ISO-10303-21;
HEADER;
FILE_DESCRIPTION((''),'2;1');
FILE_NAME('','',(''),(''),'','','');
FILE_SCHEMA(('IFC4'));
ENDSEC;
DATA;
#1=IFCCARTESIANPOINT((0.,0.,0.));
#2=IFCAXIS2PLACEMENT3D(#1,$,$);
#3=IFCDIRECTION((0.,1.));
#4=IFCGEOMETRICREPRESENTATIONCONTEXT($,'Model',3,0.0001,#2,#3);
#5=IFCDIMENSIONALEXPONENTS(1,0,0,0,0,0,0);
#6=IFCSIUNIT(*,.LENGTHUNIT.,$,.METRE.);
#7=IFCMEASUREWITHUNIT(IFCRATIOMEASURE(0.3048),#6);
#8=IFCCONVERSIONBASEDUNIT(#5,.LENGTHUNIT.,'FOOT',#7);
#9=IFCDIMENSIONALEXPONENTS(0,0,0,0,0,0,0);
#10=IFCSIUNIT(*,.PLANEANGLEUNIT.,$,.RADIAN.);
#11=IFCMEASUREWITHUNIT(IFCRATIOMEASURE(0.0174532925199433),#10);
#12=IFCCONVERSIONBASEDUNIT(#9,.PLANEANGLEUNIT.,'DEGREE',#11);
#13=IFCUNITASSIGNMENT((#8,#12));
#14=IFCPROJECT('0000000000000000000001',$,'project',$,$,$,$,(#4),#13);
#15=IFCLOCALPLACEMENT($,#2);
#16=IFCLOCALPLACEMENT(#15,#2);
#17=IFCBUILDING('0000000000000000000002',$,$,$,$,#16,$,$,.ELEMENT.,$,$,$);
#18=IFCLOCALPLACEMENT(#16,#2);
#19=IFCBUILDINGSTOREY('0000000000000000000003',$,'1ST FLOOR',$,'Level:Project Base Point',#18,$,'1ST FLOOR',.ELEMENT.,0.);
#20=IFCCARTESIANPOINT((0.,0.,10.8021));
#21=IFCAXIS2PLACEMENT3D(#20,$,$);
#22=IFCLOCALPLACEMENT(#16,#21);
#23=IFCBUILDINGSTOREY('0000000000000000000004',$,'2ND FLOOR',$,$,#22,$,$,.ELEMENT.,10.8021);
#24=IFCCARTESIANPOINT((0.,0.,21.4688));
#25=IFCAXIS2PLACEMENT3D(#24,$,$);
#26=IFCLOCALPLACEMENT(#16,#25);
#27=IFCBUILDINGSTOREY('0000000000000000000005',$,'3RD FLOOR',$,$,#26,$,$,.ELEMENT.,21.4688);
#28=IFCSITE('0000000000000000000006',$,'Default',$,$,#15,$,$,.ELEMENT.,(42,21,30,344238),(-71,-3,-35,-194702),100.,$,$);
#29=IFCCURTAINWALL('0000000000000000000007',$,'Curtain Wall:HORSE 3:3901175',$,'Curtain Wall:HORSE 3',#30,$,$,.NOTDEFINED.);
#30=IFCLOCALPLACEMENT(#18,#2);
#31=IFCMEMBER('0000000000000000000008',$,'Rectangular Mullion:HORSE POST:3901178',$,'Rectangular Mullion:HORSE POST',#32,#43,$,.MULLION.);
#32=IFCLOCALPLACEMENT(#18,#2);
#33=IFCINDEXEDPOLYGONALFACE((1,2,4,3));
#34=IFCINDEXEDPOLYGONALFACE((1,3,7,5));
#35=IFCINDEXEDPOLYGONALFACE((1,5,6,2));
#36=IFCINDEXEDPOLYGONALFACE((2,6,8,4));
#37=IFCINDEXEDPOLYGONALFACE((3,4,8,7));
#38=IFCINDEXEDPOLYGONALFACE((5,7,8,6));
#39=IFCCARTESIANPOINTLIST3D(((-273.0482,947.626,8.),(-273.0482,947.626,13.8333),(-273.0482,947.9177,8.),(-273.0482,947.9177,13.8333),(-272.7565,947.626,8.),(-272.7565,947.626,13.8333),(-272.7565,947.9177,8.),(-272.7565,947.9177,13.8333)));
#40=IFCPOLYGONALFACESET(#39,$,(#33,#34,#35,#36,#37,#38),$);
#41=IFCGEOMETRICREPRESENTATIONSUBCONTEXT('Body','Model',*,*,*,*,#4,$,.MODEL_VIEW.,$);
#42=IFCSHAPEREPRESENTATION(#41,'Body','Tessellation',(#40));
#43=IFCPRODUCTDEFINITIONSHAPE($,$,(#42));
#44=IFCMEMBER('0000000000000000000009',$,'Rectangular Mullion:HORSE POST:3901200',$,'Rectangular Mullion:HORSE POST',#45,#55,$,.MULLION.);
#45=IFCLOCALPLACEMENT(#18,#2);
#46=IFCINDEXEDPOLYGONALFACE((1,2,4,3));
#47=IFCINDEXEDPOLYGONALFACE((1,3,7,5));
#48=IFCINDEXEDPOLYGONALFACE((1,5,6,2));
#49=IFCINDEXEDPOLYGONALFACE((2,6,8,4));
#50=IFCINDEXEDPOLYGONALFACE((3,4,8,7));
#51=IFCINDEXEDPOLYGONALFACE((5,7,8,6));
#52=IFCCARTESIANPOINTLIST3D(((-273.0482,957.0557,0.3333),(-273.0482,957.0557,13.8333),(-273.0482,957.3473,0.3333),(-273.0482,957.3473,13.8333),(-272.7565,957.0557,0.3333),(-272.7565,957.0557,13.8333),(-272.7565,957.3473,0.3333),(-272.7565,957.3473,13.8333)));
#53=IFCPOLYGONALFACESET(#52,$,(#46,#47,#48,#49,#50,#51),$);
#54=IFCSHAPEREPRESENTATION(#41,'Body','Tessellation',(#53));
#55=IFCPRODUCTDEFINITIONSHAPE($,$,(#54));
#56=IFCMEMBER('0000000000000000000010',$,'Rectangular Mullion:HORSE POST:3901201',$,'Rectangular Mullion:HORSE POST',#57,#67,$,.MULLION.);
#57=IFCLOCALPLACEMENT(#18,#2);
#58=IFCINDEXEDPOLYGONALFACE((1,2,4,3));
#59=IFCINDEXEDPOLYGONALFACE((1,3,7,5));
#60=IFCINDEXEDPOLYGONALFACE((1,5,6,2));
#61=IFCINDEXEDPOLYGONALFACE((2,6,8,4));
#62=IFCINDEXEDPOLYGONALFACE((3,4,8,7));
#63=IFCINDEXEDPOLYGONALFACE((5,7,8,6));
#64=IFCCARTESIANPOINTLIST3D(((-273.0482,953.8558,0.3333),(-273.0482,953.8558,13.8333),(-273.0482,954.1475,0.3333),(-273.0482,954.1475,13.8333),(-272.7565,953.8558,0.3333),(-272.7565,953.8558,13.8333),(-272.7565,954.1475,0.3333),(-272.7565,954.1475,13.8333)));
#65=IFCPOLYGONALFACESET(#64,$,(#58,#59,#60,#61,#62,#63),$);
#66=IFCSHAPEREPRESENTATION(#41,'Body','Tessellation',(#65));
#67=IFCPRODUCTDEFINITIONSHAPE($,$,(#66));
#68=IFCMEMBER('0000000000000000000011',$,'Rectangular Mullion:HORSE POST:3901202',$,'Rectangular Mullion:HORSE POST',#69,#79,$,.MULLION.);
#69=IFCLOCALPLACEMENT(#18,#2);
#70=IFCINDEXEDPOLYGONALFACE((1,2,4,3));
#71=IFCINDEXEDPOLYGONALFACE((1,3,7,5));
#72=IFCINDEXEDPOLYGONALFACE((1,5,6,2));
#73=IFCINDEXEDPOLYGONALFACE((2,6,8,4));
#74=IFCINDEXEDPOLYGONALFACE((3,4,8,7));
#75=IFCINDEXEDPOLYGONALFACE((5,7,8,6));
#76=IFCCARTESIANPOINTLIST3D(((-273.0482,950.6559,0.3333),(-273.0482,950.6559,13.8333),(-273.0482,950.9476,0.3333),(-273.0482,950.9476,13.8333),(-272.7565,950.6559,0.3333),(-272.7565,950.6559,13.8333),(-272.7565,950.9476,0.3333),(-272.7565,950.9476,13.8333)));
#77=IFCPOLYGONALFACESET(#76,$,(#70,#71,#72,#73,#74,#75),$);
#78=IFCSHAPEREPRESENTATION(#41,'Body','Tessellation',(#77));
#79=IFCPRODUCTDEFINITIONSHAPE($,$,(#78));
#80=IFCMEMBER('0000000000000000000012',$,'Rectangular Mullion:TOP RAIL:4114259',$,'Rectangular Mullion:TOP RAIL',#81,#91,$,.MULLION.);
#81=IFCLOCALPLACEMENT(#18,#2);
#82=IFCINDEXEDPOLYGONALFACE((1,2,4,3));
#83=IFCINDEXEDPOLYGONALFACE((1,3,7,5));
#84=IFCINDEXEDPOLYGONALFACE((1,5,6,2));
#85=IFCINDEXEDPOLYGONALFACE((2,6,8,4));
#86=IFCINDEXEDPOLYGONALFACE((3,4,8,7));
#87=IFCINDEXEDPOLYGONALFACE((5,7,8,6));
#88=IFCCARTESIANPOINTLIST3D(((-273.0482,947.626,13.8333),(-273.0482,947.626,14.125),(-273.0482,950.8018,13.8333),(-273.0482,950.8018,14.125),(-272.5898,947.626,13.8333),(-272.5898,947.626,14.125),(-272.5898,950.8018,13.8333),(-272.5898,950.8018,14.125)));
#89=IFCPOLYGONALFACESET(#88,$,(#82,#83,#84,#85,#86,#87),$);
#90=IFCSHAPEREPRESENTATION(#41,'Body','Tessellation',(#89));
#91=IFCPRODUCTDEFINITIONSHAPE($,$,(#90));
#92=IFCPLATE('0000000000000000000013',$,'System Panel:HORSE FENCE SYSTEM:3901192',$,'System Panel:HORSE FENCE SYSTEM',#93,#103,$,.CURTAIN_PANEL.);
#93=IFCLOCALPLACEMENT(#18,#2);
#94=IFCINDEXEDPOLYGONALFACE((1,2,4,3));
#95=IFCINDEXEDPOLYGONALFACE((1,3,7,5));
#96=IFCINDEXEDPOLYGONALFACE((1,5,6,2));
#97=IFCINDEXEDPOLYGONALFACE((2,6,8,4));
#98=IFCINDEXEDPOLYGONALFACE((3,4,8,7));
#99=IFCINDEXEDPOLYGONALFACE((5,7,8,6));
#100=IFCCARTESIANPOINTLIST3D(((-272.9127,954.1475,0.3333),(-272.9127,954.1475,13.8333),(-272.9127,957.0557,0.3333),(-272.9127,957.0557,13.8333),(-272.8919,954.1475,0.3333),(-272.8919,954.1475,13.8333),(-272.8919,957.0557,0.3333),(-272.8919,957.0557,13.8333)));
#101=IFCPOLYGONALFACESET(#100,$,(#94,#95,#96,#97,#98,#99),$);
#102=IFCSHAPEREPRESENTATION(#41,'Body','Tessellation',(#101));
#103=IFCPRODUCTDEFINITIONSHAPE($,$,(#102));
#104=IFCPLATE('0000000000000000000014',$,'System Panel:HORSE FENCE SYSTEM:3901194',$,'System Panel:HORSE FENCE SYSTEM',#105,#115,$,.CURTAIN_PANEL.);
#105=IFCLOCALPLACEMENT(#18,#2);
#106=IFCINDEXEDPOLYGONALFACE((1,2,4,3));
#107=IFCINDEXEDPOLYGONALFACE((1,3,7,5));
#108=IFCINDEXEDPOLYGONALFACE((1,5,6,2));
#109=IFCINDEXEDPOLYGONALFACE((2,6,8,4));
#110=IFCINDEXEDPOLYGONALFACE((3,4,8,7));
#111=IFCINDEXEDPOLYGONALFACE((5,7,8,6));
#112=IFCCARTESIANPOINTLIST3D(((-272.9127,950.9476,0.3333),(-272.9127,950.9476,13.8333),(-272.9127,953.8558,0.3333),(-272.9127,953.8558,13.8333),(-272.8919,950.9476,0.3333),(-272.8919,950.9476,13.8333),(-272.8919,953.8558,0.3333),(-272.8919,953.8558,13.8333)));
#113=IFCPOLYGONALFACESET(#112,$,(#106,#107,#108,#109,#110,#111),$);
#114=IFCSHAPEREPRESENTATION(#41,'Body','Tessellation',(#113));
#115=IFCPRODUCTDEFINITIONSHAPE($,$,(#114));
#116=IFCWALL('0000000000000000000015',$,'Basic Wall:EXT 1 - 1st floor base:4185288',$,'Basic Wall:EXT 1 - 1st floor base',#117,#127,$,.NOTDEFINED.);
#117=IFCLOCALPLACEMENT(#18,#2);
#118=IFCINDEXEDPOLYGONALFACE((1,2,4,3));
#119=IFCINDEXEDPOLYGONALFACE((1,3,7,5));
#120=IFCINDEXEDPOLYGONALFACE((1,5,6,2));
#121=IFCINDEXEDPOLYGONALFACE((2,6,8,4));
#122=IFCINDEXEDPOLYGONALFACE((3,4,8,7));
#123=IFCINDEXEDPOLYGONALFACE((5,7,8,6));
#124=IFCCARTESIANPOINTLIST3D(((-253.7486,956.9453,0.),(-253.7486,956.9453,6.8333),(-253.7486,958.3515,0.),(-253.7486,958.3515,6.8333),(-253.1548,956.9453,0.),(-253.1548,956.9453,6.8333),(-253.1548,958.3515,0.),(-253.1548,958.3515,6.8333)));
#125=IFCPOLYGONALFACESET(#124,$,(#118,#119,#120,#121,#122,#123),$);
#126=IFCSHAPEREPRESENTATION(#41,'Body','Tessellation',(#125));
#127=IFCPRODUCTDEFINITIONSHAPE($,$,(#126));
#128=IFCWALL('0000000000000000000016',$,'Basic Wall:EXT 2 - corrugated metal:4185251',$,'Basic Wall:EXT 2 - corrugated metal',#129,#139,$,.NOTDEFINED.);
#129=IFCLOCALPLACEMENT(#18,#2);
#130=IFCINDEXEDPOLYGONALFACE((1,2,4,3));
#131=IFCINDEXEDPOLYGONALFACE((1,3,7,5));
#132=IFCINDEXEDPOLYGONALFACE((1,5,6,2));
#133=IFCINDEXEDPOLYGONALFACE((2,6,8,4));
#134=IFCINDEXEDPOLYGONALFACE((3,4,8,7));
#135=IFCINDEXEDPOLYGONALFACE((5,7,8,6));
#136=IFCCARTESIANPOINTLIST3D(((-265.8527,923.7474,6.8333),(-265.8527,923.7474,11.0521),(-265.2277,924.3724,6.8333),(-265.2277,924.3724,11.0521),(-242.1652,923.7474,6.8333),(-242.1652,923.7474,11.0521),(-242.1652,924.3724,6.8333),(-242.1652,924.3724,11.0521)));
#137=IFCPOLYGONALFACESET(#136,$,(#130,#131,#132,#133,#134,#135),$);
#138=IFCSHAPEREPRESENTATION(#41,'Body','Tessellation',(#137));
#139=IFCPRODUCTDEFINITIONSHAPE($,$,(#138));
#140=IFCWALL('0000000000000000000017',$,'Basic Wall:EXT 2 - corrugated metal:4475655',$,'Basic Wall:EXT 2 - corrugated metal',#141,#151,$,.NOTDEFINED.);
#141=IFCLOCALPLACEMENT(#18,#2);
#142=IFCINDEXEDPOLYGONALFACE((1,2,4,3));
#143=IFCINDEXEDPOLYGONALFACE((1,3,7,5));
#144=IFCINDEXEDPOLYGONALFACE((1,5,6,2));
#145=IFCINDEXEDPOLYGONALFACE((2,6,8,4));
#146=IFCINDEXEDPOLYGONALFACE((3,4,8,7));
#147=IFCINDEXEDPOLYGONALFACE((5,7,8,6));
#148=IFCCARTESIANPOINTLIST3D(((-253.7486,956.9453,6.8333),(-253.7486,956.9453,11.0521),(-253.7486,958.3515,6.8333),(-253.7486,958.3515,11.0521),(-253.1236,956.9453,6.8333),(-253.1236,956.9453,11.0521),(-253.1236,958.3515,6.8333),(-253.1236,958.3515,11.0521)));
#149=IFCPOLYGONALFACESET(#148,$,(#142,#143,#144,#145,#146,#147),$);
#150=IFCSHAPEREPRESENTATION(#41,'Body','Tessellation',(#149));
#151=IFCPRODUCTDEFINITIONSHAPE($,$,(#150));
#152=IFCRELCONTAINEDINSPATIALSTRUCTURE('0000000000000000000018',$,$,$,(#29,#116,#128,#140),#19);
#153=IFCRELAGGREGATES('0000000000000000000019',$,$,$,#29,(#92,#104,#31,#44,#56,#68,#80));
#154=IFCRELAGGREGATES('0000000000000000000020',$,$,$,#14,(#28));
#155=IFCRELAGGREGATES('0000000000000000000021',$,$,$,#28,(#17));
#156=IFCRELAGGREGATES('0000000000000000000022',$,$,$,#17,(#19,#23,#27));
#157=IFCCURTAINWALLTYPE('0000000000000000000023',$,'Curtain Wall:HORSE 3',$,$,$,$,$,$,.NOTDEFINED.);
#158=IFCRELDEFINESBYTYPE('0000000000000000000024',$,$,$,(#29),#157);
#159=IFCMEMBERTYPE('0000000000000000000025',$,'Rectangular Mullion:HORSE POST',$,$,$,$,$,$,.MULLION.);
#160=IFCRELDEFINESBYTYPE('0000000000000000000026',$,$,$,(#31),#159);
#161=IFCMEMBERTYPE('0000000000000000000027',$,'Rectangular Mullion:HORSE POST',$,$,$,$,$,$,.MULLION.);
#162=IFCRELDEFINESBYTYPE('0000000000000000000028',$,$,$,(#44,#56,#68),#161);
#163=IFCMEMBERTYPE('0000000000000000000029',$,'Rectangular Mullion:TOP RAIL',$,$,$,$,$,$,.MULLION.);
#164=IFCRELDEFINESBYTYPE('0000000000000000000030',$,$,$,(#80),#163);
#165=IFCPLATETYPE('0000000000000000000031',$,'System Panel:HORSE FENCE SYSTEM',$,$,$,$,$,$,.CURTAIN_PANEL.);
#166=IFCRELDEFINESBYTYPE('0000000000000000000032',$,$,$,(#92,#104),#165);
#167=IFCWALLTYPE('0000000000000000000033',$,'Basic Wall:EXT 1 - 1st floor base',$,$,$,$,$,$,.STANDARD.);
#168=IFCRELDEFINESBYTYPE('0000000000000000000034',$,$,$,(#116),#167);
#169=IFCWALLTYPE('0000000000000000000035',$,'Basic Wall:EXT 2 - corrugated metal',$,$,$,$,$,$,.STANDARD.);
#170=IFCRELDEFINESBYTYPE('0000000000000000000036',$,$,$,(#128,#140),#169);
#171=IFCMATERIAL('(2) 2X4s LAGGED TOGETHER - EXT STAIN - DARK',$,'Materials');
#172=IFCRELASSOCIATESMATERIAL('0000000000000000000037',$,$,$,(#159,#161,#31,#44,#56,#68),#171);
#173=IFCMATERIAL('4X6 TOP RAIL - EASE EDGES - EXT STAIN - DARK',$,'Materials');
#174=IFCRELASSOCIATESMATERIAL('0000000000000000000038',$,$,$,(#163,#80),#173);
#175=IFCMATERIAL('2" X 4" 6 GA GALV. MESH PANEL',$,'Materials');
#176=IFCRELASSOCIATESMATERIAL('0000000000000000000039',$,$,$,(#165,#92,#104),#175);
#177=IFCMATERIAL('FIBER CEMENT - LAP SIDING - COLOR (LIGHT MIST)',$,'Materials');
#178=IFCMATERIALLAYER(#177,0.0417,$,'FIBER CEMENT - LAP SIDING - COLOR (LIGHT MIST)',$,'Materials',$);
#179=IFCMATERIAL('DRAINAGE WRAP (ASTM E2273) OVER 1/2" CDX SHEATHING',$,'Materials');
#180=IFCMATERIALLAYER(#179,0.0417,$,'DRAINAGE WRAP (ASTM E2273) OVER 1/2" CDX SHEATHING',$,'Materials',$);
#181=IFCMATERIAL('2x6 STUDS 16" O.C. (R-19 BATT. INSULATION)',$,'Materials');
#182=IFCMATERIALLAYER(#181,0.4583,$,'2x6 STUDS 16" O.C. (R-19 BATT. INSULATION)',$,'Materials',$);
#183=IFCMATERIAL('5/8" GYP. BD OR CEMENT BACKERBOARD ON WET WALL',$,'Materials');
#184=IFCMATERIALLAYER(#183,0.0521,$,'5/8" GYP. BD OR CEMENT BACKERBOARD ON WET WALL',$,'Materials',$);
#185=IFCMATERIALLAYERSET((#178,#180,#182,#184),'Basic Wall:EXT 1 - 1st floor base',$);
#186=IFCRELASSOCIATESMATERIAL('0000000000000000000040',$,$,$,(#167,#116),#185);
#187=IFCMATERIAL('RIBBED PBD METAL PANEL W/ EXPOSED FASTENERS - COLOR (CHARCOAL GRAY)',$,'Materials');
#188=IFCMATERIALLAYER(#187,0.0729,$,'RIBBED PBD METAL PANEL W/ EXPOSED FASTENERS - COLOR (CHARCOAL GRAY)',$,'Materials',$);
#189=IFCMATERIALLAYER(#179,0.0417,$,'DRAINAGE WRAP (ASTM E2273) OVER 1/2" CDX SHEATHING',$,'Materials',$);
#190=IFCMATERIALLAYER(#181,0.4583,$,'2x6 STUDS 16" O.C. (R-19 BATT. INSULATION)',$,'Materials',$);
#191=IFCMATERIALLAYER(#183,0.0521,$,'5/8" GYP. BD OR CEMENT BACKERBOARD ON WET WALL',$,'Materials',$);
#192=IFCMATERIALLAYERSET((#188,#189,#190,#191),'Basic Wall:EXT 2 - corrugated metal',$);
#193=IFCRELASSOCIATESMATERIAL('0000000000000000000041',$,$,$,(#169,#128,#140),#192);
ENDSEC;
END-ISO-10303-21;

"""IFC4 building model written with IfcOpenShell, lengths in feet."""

from ifc_helpers import new_model, entity, si_unit, converted_unit, direction, frame, frame_2d, origin, origin_2d_with_axis, place, context, subcontext, project, spatial, polyline, rectangle, outline, extrude, source, transform, mapped, material, layer, layer_set, layer_usage, material_profile, profile_set, profile_usage, type_object, type_shapes, element, aggregate, save


model = new_model("IFC4")

# Units and contexts
model_context = context("Model", 3, precision=0.0001, world=origin(), true_north=direction((0.0, 1.0)))
body_context = subcontext(model_context, "Body", "Model", "MODEL_VIEW")
ifc_project = project(units=[converted_unit("LENGTHUNIT", "FOOT", entity("IfcRatioMeasure", 0.3048), si_unit("LENGTHUNIT", "METRE"), dimensions=[1, 0, 0, 0, 0, 0, 0]), converted_unit("PLANEANGLEUNIT", "DEGREE", entity("IfcRatioMeasure", 0.0174532925199433), si_unit("PLANEANGLEUNIT", "RADIAN"), dimensions=[0, 0, 0, 0, 0, 0, 0])], contexts=[model_context])

# Site, building, storey
site_placement = place(None, origin())
site = spatial("IfcSite", under=ifc_project, at=site_placement, Name="Default", CompositionType="ELEMENT", RefLatitude=(42, 21, 30, 344238), RefLongitude=(-71, -3, -35, -194702), RefElevation=100.0)
building_placement = place(site_placement, origin())
building = spatial("IfcBuilding", under=site, at=building_placement, CompositionType="ELEMENT")
storey_1_placement = place(building_placement, origin())
storey_1 = spatial("IfcBuildingStorey", under=building, at=storey_1_placement, Name="1ST FLOOR", ObjectType="Level:Project Base Point", LongName="1ST FLOOR", CompositionType="ELEMENT", Elevation=0.0)

# Curtain wall, members, plates
curtain_wall_type = type_object("IfcCurtainWallType", Name="Curtain Wall:HORSE 3", PredefinedType="NOTDEFINED")
curtain_wall_placement = place(storey_1_placement, origin())
curtain_wall = element("IfcCurtainWall", 1, at=curtain_wall_placement, inside=storey_1, type_object=curtain_wall_type, Name="Curtain Wall:HORSE 3:3901175", ObjectType="Curtain Wall:HORSE 3", PredefinedType="NOTDEFINED")
ifc_material_1 = material(Name="(2) 2X4s LAGGED TOGETHER - EXT STAIN - DARK", Category="Materials")
ifc_material_profile_1 = material_profile(ifc_material_1, rectangle(XDim=0.2917, YDim=0.2917, at=frame_2d((0.0, 0.0), x_axis=(1.0, 0.0))), Name="HORSE POST")
ifc_profile_set_1 = profile_set([ifc_material_profile_1], Name="HORSE POST")
ifc_profile_usage_1 = profile_usage(ifc_profile_set_1)
member_type_1 = type_object("IfcMemberType", Name="Rectangular Mullion:HORSE POST", PredefinedType="MULLION", material=ifc_profile_set_1)
shared_shape_1 = source(origin(), body_context, "Body", "SweptSolid", [
    extrude(rectangle(XDim=0.2917, YDim=0.2917, at=origin_2d_with_axis()), frame((-0.1458, 0.1458, -5.8333), z_axis=(0.0, 0.0, 1.0), x_axis=(0.0, -1.0, 0.0)), (0.0, 0.0, 1.0), 5.8333),
])
type_shapes(member_type_1, [shared_shape_1])
storey_2_placement = place(building_placement, frame((0.0, 0.0, 21.4688)))
member_1_placement = place(storey_2_placement, frame((-272.7565, 947.626, -13.4688), z_axis=(0.0, 0.0, -1.0), x_axis=(0.0, -1.0, 0.0)))
member_1 = element("IfcMember", 2, at=member_1_placement, type_object=member_type_1, material=ifc_profile_usage_1, Name="Rectangular Mullion:HORSE POST:3901178", ObjectType="Rectangular Mullion:HORSE POST", PredefinedType="MULLION", context=body_context, shape_type="MappedRepresentation", body=[
    mapped(shared_shape_1, transform((0.0, 0.0, 0.0), scale=1.0)),
])
ifc_material_2 = material(Name="4X6 TOP RAIL - EASE EDGES - EXT STAIN - DARK", Category="Materials")
ifc_material_profile_2 = material_profile(ifc_material_2, rectangle(XDim=0.4583, YDim=0.2917, at=origin_2d_with_axis()), Name="TOP RAIL")
ifc_profile_set_2 = profile_set([ifc_material_profile_2], Name="TOP RAIL")
storey_3_placement = place(building_placement, frame((0.0, 0.0, 10.8021)))
ifc_profile_usage_2 = profile_usage(ifc_profile_set_1)
member_type_2 = type_object("IfcMemberType", Name="Rectangular Mullion:HORSE POST", PredefinedType="MULLION", material=ifc_profile_set_1)
shared_shape_2 = source(origin(), body_context, "Body", "SweptSolid", [
    extrude(rectangle(XDim=0.2917, YDim=0.2917, at=origin_2d_with_axis()), frame((0.0, 0.1458, -13.5), z_axis=(0.0, 0.0, 1.0), x_axis=(0.0, -1.0, 0.0)), (0.0, 0.0, 1.0), 13.5),
])
type_shapes(member_type_2, [shared_shape_2])
member_2_placement = place(storey_3_placement, frame((-272.7565, 957.2015, -10.4688), z_axis=(0.0, 0.0, -1.0), x_axis=(0.0, -1.0, 0.0)))
member_2 = element("IfcMember", 3, at=member_2_placement, type_object=member_type_2, material=ifc_profile_usage_2, Name="Rectangular Mullion:HORSE POST:3901200", ObjectType="Rectangular Mullion:HORSE POST", PredefinedType="MULLION", context=body_context, shape_type="MappedRepresentation", body=[
    mapped(shared_shape_2, transform((0.0, 0.0, 0.0), scale=1.0)),
])
ifc_profile_usage_3 = profile_usage(ifc_profile_set_1)
member_3_placement = place(storey_3_placement, frame((-272.7565, 954.0016, -10.4688), z_axis=(0.0, 0.0, -1.0), x_axis=(0.0, -1.0, 0.0)))
member_3 = element("IfcMember", 4, at=member_3_placement, type_object=member_type_2, material=ifc_profile_usage_3, Name="Rectangular Mullion:HORSE POST:3901201", ObjectType="Rectangular Mullion:HORSE POST", PredefinedType="MULLION", context=body_context, shape_type="MappedRepresentation", body=[
    mapped(shared_shape_2, transform((0.0, 0.0, 0.0), scale=1.0)),
])
ifc_profile_usage_4 = profile_usage(ifc_profile_set_1)
member_4_placement = place(storey_3_placement, frame((-272.7565, 950.8018, -10.4688), z_axis=(0.0, 0.0, -1.0), x_axis=(0.0, -1.0, 0.0)))
member_4 = element("IfcMember", 5, at=member_4_placement, type_object=member_type_2, material=ifc_profile_usage_4, Name="Rectangular Mullion:HORSE POST:3901202", ObjectType="Rectangular Mullion:HORSE POST", PredefinedType="MULLION", context=body_context, shape_type="MappedRepresentation", body=[
    mapped(shared_shape_2, transform((0.0, 0.0, 0.0), scale=1.0)),
])
ifc_profile_usage_5 = profile_usage(ifc_profile_set_2)
member_type_3 = type_object("IfcMemberType", Name="Rectangular Mullion:TOP RAIL", PredefinedType="MULLION", material=ifc_profile_set_2)
shared_shape_3 = source(origin(), body_context, "Body", "SweptSolid", [
    extrude(rectangle(XDim=0.4583, YDim=0.2917, at=origin_2d_with_axis()), frame((-0.1458, 0.0625, -3.1758), z_axis=(0.0, 0.0, 1.0), x_axis=(0.0, -1.0, 0.0)), (0.0, 0.0, 1.0), 3.1758),
])
type_shapes(member_type_3, [shared_shape_3])
member_5_placement = place(storey_1_placement, frame((-272.7565, 947.626, 14.125), z_axis=(0.0, -1.0, 0.0), x_axis=(0.0, 0.0, 1.0)))
member_5 = element("IfcMember", 6, at=member_5_placement, type_object=member_type_3, material=ifc_profile_usage_5, Name="Rectangular Mullion:TOP RAIL:4114259", ObjectType="Rectangular Mullion:TOP RAIL", PredefinedType="MULLION", context=body_context, shape_type="MappedRepresentation", body=[
    mapped(shared_shape_3, transform((0.0, 0.0, 0.0), scale=1.0)),
])
ifc_material_3 = material(Name="2\" X 4\" 6 GA GALV. MESH PANEL", Category="Materials")
plate_type = type_object("IfcPlateType", Name="System Panel:HORSE FENCE SYSTEM", PredefinedType="CURTAIN_PANEL", material=ifc_material_3)
shared_shape_4 = source(origin(), body_context, "Body", "SweptSolid", [
    extrude(rectangle(XDim=0.0208, YDim=2.9082, at=frame_2d((0.0, 0.0), x_axis=(1.0, 0.0))), frame((1.4541, 0.0104, 0.0), z_axis=(0.0, 0.0, 1.0), x_axis=(0.0, 1.0, 0.0)), (0.0, 0.0, 1.0), 13.5),
])
type_shapes(plate_type, [shared_shape_4])
plate_1_placement = place(curtain_wall_placement, frame((-272.9127, 957.0557, 0.3333), z_axis=(0.0, 0.0, 1.0), x_axis=(0.0, -1.0, 0.0)))
plate_1 = element("IfcPlate", 7, at=plate_1_placement, type_object=plate_type, material=ifc_material_3, Name="System Panel:HORSE FENCE SYSTEM:3901192", ObjectType="System Panel:HORSE FENCE SYSTEM", PredefinedType="CURTAIN_PANEL", context=body_context, shape_type="MappedRepresentation", body=[
    mapped(shared_shape_4, transform((0.0, 0.0, 0.0), scale=1.0)),
])
plate_2_placement = place(curtain_wall_placement, frame((-272.9127, 953.8558, 0.3333), z_axis=(0.0, 0.0, 1.0), x_axis=(0.0, -1.0, 0.0)))
plate_2 = element("IfcPlate", 8, at=plate_2_placement, type_object=plate_type, material=ifc_material_3, Name="System Panel:HORSE FENCE SYSTEM:3901194", ObjectType="System Panel:HORSE FENCE SYSTEM", PredefinedType="CURTAIN_PANEL", context=body_context, shape_type="MappedRepresentation", body=[
    mapped(shared_shape_4, transform((0.0, 0.0, 0.0), scale=1.0)),
])
aggregate(curtain_wall, [plate_1, plate_2, member_1, member_2, member_3, member_4, member_5])

# Shared definitions
ifc_material_4 = material(Name="FIBER CEMENT - LAP SIDING - COLOR (LIGHT MIST)", Category="Materials")
ifc_layer_1 = layer(ifc_material_4, 0.0417, Name="FIBER CEMENT - LAP SIDING - COLOR (LIGHT MIST)", Category="Materials")
ifc_material_5 = material(Name="DRAINAGE WRAP (ASTM E2273) OVER 1/2\" CDX SHEATHING", Category="Materials")
ifc_layer_2 = layer(ifc_material_5, 0.0417, Name="DRAINAGE WRAP (ASTM E2273) OVER 1/2\" CDX SHEATHING", Category="Materials")
ifc_material_6 = material(Name="2x6 STUDS 16\" O.C. (R-19 BATT. INSULATION)", Category="Materials")
ifc_layer_3 = layer(ifc_material_6, 0.4583, Name="2x6 STUDS 16\" O.C. (R-19 BATT. INSULATION)", Category="Materials")
ifc_material_7 = material(Name="5/8\" GYP. BD OR CEMENT BACKERBOARD ON WET WALL", Category="Materials")
ifc_layer_4 = layer(ifc_material_7, 0.0521, Name="5/8\" GYP. BD OR CEMENT BACKERBOARD ON WET WALL", Category="Materials")
ifc_layer_set_1 = layer_set([ifc_layer_1, ifc_layer_2, ifc_layer_3, ifc_layer_4], Name="Basic Wall:EXT 1 - 1st floor base")
wall_type_1 = type_object("IfcWallType", Name="Basic Wall:EXT 1 - 1st floor base", PredefinedType="STANDARD", material=ifc_layer_set_1)

# Walls
ifc_layer_usage_1 = layer_usage(ifc_layer_set_1, "AXIS2", "POSITIVE", -0.2969)
wall_1_placement = place(storey_1_placement, frame((-253.4517, 956.9453, 0.0), z_axis=(0.0, 0.0, 1.0), x_axis=(0.0, 1.0, 0.0)))
element("IfcWall", 9, at=wall_1_placement, inside=storey_1, type_object=wall_type_1, material=ifc_layer_usage_1, Name="Basic Wall:EXT 1 - 1st floor base:4185288", ObjectType="Basic Wall:EXT 1 - 1st floor base", PredefinedType="NOTDEFINED", context=body_context, shape_type="SweptSolid", body=[
    extrude(rectangle(XDim=1.4062, YDim=0.5938, at=frame_2d((0.7031, 0.0), x_axis=(-1.0, 0.0))), origin(), (0.0, 0.0, 1.0), 6.8333),
])
ifc_material_8 = material(Name="RIBBED PBD METAL PANEL W/ EXPOSED FASTENERS - COLOR (CHARCOAL GRAY)", Category="Materials")
ifc_layer_5 = layer(ifc_material_8, 0.0729, Name="RIBBED PBD METAL PANEL W/ EXPOSED FASTENERS - COLOR (CHARCOAL GRAY)", Category="Materials")
ifc_layer_6 = layer(ifc_material_5, 0.0417, Name="DRAINAGE WRAP (ASTM E2273) OVER 1/2\" CDX SHEATHING", Category="Materials")
ifc_layer_7 = layer(ifc_material_6, 0.4583, Name="2x6 STUDS 16\" O.C. (R-19 BATT. INSULATION)", Category="Materials")
ifc_layer_8 = layer(ifc_material_7, 0.0521, Name="5/8\" GYP. BD OR CEMENT BACKERBOARD ON WET WALL", Category="Materials")
ifc_layer_set_2 = layer_set([ifc_layer_5, ifc_layer_6, ifc_layer_7, ifc_layer_8], Name="Basic Wall:EXT 2 - corrugated metal")
ifc_layer_usage_2 = layer_usage(ifc_layer_set_2, "AXIS2", "POSITIVE", -0.3125)
wall_type_2 = type_object("IfcWallType", Name="Basic Wall:EXT 2 - corrugated metal", PredefinedType="STANDARD", material=ifc_layer_set_2)
wall_2_placement = place(storey_1_placement, frame((-265.8527, 924.0599, 6.8333)))
element("IfcWall", 10, at=wall_2_placement, inside=storey_1, type_object=wall_type_2, material=ifc_layer_usage_2, Name="Basic Wall:EXT 2 - corrugated metal:4185251", ObjectType="Basic Wall:EXT 2 - corrugated metal", PredefinedType="NOTDEFINED", context=body_context, shape_type="SweptSolid", body=[
    extrude(outline(polyline([(23.6875, -0.3125), (23.6875, 0.3125), (0.625, 0.3125), (0.0, -0.3125), (23.6875, -0.3125)])), origin(), (0.0, 0.0, 1.0), 4.2187),
])
ifc_layer_usage_3 = layer_usage(ifc_layer_set_2, "AXIS2", "POSITIVE", -0.3125)
wall_3_placement = place(storey_1_placement, frame((-253.4361, 956.9453, 6.8333), z_axis=(0.0, 0.0, 1.0), x_axis=(0.0, 1.0, 0.0)))
element("IfcWall", 11, at=wall_3_placement, inside=storey_1, type_object=wall_type_2, material=ifc_layer_usage_3, Name="Basic Wall:EXT 2 - corrugated metal:4475655", ObjectType="Basic Wall:EXT 2 - corrugated metal", PredefinedType="NOTDEFINED", context=body_context, shape_type="SweptSolid", body=[
    extrude(rectangle(XDim=1.4062, YDim=0.625, at=frame_2d((0.7031, 0.0), x_axis=(-1.0, 0.0))), origin(), (0.0, 0.0, 1.0), 4.2187),
])

# Shared definitions
storey_3 = spatial("IfcBuildingStorey", under=building, at=storey_3_placement, Name="2ND FLOOR", CompositionType="ELEMENT", Elevation=10.8021)

# Shared definitions
storey_2 = spatial("IfcBuildingStorey", under=building, at=storey_2_placement, Name="3RD FLOOR", CompositionType="ELEMENT", Elevation=21.4688)

save(model, "model.ifc")
